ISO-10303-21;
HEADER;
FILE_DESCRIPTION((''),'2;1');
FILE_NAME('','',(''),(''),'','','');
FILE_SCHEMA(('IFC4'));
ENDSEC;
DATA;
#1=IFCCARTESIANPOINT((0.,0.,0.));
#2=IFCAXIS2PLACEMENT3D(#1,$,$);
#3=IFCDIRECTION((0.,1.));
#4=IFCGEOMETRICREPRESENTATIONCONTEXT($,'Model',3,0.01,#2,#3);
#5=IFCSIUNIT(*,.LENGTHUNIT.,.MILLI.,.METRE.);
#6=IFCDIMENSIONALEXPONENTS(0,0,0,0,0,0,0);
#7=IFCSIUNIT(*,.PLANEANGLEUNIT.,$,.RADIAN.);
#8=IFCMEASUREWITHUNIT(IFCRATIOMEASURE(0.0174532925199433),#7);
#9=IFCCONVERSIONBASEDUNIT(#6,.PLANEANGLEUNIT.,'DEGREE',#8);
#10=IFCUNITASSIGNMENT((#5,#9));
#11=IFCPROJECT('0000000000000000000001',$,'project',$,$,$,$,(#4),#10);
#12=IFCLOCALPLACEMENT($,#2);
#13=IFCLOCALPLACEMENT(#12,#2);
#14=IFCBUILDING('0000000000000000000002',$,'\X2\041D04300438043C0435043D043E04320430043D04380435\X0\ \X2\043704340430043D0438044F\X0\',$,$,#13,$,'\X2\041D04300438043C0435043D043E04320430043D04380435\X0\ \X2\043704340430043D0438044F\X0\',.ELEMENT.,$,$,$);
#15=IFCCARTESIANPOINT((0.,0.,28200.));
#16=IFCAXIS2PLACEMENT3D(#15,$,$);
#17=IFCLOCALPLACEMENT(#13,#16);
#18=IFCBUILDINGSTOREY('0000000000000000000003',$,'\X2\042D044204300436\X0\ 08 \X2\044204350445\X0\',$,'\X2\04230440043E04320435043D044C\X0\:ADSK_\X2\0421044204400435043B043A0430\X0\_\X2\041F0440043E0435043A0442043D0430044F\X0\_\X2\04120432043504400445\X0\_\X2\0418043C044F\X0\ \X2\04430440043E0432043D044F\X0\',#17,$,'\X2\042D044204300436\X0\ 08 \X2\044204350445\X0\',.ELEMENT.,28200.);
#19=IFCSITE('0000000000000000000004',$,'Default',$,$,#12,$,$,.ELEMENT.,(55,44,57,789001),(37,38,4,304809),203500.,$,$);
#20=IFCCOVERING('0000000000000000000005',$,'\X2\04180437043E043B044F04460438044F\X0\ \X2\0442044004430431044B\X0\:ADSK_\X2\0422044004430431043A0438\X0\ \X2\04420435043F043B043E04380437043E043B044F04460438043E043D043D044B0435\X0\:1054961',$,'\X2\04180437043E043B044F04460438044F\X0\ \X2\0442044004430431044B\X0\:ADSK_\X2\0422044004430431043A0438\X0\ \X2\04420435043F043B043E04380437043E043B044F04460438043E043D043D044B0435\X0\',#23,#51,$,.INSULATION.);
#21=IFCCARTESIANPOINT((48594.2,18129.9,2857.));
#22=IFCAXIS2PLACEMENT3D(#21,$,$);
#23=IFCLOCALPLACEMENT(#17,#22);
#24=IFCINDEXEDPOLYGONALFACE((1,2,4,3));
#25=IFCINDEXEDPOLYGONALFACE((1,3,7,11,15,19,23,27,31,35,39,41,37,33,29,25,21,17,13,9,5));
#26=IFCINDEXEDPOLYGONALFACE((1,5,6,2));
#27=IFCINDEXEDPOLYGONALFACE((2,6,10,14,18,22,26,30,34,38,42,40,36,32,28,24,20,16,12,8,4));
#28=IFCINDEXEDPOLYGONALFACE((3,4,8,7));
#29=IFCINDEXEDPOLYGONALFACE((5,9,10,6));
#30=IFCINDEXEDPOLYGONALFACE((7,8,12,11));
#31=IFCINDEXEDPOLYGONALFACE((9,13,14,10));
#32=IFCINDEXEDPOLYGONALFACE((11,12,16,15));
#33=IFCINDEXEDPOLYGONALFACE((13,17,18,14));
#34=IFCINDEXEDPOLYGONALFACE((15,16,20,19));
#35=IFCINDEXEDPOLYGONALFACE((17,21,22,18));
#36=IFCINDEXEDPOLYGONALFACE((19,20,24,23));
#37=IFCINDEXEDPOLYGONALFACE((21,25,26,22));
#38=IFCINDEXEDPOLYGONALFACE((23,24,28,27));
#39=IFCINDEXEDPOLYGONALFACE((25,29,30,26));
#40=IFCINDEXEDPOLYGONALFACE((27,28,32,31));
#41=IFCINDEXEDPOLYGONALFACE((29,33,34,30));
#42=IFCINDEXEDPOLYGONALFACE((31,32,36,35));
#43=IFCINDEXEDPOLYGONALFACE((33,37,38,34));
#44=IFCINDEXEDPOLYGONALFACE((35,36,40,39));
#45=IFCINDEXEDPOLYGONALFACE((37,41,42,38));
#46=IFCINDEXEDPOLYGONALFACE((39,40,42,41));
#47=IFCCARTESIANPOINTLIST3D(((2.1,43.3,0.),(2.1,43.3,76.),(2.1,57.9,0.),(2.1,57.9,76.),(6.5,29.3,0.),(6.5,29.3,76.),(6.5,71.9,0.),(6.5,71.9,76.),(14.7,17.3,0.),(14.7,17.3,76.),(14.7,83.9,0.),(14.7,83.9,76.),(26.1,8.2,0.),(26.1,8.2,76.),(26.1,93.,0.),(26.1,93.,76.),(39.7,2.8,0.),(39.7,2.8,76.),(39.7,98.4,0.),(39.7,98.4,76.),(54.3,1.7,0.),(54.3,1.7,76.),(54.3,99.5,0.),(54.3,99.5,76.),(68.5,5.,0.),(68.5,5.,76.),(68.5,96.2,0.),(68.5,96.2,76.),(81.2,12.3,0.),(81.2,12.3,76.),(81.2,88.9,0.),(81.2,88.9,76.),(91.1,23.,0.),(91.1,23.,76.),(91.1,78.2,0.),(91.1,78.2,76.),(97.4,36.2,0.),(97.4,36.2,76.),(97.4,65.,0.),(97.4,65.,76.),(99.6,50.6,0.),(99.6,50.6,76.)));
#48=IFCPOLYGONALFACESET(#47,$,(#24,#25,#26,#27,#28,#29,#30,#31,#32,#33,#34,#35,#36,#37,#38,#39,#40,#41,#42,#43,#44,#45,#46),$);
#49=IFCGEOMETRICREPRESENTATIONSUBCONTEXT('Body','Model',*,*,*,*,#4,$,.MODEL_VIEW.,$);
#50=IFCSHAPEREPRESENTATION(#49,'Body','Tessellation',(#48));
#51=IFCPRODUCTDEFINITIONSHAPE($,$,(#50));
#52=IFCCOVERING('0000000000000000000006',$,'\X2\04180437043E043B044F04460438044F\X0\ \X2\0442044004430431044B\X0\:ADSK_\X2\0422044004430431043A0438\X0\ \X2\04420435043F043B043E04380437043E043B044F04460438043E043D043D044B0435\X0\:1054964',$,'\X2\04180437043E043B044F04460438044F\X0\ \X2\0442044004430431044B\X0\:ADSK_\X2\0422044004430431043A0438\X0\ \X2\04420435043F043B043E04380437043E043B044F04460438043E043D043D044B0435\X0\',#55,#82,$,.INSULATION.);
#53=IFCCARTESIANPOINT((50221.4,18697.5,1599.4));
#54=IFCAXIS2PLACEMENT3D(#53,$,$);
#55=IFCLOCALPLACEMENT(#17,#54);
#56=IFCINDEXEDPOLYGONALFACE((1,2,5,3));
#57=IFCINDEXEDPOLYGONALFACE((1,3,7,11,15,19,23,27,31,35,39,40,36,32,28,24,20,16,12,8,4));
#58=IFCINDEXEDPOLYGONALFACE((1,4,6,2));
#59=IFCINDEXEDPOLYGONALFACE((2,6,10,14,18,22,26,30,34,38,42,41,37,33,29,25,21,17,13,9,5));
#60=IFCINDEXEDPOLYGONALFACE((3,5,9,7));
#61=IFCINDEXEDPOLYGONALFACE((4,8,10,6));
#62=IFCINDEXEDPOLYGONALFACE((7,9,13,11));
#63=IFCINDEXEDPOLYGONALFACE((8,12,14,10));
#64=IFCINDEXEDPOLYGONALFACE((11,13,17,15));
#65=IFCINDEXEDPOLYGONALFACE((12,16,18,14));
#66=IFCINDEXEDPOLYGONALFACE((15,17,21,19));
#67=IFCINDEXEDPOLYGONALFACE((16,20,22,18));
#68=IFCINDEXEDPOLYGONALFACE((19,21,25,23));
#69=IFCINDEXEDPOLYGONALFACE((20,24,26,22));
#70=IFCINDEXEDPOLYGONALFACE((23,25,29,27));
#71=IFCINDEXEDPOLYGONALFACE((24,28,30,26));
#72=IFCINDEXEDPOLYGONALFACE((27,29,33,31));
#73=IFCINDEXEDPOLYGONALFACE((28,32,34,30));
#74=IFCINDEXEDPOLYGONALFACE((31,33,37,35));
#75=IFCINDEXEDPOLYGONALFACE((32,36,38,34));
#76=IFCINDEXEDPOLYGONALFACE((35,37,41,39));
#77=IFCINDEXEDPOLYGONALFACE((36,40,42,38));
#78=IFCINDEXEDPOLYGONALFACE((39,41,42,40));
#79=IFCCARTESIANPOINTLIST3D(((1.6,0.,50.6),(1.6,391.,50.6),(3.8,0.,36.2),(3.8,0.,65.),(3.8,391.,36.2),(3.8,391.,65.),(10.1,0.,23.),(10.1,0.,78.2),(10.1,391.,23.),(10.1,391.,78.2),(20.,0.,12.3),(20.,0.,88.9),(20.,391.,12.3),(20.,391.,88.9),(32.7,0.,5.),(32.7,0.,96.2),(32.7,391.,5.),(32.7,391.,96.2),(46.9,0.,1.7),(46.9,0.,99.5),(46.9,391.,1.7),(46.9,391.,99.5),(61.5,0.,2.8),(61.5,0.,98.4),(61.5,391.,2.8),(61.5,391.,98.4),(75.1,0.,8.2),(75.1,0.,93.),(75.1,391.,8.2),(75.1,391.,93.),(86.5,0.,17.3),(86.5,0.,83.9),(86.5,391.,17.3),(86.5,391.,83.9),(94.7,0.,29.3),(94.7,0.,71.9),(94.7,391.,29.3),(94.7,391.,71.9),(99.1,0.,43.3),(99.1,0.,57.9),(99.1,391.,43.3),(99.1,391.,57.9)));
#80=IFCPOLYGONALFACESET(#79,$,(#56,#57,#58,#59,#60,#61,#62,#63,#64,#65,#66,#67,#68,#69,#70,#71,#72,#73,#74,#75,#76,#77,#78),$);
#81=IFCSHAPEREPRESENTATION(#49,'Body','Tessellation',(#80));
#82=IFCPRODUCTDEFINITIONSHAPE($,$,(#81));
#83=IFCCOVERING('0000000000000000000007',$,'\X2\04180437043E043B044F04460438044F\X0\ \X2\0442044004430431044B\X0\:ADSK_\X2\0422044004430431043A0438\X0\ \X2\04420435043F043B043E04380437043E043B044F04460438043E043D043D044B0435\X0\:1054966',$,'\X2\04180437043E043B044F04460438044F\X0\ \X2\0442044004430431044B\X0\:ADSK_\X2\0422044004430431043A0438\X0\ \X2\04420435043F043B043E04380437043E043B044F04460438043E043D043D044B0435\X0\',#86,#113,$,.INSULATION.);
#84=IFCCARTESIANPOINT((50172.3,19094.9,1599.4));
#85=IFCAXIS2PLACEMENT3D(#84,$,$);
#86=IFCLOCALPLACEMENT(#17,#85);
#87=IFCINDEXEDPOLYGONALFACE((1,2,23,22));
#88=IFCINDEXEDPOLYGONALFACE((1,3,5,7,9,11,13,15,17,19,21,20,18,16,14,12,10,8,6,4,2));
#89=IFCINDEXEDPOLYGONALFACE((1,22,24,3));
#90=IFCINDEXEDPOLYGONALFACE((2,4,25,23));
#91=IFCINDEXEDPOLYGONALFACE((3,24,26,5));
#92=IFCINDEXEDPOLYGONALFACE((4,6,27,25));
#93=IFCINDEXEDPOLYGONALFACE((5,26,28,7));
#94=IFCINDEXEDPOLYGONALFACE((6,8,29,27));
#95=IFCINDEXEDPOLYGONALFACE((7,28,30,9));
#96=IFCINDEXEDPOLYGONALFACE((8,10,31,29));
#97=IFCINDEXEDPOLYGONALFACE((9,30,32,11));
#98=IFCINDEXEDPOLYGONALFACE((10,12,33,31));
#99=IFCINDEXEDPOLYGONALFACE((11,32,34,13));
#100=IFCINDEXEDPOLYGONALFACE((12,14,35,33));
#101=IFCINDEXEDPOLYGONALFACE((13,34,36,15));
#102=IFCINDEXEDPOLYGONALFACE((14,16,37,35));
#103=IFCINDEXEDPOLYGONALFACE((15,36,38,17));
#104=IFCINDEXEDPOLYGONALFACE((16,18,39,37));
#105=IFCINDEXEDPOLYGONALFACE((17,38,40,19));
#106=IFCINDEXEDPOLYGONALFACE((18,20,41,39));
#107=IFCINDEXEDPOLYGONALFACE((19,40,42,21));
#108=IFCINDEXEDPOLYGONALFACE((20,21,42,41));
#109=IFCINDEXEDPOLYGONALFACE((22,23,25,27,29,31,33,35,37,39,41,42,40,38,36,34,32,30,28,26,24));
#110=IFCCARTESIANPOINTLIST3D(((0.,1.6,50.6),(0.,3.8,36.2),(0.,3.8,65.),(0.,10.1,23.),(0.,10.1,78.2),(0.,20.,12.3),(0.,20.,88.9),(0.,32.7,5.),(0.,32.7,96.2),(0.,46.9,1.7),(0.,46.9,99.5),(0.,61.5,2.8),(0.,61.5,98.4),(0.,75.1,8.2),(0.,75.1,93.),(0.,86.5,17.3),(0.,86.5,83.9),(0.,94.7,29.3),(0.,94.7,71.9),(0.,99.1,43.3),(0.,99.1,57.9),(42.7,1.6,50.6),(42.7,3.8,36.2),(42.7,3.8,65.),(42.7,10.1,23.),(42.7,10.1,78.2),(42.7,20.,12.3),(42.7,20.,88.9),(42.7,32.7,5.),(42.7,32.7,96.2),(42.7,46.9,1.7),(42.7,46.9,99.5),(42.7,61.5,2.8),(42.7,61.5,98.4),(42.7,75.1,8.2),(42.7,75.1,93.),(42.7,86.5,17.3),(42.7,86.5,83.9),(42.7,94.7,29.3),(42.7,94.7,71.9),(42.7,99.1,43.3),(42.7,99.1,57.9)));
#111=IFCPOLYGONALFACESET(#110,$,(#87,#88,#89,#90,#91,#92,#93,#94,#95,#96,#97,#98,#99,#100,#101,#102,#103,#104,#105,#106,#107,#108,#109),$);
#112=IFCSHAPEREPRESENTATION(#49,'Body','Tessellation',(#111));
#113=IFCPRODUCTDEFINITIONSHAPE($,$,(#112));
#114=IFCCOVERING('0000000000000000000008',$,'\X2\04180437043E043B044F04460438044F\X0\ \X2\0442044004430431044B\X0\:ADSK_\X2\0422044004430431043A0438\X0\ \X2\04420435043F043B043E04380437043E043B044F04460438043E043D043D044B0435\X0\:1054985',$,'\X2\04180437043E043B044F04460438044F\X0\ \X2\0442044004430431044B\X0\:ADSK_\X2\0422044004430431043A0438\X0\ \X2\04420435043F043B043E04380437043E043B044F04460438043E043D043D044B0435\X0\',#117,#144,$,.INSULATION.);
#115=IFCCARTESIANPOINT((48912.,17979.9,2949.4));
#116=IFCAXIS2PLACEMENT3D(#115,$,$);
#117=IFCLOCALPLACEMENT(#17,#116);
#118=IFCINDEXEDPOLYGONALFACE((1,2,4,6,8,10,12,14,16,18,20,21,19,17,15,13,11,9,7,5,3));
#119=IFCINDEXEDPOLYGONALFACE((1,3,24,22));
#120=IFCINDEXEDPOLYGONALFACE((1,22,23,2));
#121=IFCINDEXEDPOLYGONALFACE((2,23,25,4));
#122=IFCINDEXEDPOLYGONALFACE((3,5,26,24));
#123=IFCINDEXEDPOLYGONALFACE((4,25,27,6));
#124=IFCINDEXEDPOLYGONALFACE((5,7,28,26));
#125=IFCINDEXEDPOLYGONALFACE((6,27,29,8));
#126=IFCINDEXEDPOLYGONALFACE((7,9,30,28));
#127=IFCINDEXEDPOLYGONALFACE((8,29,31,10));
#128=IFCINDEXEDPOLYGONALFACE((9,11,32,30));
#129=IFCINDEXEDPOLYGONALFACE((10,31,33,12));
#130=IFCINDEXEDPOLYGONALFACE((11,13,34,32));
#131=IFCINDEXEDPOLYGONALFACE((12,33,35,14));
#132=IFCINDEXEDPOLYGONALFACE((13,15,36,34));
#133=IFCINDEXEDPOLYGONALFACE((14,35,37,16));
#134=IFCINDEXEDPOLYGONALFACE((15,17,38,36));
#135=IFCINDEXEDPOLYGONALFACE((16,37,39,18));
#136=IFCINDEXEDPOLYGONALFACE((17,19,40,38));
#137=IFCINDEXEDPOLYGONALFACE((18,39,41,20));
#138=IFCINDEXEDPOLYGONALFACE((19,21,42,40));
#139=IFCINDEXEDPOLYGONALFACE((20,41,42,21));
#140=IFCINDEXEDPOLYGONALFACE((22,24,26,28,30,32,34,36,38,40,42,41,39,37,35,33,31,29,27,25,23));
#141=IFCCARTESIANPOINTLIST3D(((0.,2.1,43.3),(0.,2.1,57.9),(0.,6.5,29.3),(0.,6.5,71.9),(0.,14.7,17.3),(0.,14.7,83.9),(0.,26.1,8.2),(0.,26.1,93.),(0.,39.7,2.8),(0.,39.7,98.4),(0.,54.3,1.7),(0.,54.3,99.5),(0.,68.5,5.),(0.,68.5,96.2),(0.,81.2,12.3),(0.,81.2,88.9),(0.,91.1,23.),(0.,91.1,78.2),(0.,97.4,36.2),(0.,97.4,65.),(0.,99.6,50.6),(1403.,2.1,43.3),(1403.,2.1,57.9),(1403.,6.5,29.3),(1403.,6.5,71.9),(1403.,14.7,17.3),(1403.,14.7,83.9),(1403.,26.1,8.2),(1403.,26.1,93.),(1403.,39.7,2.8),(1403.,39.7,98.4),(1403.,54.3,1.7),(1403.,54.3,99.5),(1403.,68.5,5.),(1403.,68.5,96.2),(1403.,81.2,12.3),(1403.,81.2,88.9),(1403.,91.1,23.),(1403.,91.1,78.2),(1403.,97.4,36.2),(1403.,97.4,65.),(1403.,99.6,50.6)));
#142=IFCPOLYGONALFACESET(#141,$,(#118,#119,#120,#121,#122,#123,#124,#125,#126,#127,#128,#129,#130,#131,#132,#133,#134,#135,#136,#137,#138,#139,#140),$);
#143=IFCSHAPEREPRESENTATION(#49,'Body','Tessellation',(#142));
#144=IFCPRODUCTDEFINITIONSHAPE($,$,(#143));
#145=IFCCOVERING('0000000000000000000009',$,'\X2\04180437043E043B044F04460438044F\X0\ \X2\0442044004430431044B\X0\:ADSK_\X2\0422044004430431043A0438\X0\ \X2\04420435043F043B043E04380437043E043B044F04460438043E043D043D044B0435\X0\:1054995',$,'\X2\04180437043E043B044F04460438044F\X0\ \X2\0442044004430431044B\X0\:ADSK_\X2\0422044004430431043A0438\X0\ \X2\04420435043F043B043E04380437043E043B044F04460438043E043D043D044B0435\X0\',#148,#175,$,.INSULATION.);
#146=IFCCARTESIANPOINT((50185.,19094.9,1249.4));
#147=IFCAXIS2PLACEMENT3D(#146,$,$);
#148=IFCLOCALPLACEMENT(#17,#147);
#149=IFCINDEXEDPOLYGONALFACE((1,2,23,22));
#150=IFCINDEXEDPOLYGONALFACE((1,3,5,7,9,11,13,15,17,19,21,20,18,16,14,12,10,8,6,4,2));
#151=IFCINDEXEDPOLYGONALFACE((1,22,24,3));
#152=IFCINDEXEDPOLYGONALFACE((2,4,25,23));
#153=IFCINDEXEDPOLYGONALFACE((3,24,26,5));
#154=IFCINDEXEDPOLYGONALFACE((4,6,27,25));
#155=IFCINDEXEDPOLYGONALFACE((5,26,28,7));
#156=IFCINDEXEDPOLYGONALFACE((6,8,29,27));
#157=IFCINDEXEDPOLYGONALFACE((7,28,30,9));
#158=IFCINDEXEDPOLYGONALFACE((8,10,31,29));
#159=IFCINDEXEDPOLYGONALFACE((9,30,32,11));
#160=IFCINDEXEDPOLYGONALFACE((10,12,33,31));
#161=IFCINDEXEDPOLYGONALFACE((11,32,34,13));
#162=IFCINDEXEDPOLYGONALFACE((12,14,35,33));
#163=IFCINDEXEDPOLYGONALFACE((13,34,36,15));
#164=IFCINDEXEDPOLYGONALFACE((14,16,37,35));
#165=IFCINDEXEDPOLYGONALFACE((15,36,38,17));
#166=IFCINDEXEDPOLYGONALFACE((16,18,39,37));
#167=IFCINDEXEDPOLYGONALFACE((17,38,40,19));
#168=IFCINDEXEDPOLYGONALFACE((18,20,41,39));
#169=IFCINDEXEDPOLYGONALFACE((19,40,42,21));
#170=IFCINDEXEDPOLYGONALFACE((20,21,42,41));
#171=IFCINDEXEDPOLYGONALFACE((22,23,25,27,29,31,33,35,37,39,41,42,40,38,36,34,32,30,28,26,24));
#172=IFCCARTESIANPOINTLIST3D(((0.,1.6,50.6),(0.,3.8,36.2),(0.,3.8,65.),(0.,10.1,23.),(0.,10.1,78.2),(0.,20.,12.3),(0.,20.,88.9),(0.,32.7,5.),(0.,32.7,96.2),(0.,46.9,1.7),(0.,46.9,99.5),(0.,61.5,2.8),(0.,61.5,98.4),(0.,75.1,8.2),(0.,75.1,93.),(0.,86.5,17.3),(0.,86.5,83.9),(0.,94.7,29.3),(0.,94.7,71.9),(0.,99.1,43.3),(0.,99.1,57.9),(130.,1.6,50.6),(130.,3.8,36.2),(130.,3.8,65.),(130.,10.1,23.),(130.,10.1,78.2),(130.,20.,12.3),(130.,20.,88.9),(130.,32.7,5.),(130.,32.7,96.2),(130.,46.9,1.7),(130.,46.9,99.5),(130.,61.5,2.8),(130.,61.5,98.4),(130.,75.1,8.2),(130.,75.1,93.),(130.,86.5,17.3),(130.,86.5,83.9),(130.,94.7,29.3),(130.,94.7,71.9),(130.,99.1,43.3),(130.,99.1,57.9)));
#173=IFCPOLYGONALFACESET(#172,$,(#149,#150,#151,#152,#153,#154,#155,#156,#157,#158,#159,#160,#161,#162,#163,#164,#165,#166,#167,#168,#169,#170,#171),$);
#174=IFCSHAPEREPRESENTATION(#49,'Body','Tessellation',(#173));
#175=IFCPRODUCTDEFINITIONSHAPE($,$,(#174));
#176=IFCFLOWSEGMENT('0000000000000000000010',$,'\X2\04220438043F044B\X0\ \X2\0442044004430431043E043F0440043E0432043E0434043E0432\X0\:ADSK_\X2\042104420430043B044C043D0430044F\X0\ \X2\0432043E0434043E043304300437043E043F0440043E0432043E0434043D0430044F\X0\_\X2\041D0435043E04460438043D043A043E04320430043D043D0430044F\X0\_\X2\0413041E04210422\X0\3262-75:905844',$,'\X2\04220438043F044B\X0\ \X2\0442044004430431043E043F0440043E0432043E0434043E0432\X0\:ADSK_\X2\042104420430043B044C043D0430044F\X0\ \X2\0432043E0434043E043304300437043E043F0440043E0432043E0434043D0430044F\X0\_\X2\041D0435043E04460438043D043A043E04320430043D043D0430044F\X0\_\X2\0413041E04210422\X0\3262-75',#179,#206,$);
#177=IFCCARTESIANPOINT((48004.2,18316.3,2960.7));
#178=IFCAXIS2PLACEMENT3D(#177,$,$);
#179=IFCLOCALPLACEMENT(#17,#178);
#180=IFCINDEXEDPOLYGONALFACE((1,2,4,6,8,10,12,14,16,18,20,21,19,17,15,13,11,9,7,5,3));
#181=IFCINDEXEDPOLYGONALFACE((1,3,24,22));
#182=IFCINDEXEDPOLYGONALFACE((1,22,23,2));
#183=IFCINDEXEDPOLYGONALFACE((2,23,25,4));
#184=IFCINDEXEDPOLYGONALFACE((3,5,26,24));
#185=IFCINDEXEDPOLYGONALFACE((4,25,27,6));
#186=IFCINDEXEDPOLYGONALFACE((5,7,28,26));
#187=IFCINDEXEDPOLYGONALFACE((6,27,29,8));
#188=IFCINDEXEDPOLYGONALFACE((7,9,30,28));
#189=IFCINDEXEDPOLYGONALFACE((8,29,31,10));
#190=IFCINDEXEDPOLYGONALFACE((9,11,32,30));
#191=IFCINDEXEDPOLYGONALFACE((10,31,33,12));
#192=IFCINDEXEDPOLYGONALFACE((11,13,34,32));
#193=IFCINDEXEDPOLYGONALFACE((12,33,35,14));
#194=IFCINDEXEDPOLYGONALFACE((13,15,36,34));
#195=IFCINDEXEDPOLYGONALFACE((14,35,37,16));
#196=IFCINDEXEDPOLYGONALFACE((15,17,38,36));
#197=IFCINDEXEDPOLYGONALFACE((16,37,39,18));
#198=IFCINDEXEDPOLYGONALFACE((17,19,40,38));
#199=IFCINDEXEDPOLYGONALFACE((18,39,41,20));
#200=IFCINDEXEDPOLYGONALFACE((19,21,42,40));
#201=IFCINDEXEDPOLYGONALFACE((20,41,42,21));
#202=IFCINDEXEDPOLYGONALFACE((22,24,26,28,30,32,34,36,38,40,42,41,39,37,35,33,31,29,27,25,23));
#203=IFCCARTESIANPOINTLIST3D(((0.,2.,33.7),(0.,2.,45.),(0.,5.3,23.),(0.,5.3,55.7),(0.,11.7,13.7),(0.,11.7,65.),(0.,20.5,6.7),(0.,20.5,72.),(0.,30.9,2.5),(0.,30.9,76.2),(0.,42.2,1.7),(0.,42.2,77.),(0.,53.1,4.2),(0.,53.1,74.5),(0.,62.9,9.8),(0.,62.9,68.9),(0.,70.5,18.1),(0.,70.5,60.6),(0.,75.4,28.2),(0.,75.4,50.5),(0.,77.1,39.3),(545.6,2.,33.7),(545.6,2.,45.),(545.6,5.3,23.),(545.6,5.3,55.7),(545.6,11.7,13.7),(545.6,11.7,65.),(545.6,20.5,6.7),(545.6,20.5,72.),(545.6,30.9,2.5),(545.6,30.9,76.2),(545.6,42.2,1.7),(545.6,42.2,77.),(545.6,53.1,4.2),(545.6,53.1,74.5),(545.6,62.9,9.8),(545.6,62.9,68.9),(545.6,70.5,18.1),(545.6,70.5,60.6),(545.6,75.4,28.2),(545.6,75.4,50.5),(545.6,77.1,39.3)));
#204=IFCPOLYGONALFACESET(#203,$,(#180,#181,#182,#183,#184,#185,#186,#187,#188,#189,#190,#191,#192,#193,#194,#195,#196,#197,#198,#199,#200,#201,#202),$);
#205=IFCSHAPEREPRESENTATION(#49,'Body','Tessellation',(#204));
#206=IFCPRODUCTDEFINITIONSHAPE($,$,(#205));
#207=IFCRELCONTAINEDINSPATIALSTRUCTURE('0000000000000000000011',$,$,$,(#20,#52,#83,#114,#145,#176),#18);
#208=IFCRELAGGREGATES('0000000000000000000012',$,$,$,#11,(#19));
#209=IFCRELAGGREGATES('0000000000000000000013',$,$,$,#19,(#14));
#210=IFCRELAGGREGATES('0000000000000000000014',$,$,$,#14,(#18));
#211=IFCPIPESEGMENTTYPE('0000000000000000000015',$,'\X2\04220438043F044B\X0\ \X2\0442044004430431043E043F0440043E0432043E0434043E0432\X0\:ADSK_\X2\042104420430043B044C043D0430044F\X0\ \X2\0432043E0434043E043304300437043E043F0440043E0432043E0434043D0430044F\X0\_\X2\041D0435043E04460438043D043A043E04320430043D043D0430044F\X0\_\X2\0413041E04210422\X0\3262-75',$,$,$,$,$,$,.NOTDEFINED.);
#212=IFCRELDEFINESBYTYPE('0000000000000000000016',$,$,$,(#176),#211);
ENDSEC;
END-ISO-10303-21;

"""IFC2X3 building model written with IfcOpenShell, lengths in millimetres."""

from ifc_helpers import new_model, entity, si_unit, converted_unit, direction, frame, origin, origin_2d_with_axis, place, context, subcontext, project, spatial, circle, extrude, type_object, element, save


model = new_model("IFC2X3")

# Units and contexts
model_context = context("Model", 3, precision=0.01, world=origin(), true_north=direction((0.0, 1.0)))
body_context = subcontext(model_context, "Body", "Model", "MODEL_VIEW")
ifc_project = project(units=[si_unit("LENGTHUNIT", "METRE", prefix="MILLI"), converted_unit("PLANEANGLEUNIT", "DEGREE", entity("IfcRatioMeasure", 0.0174532925199433), si_unit("PLANEANGLEUNIT", "RADIAN"), dimensions=[0, 0, 0, 0, 0, 0, 0])], contexts=[model_context])

# Site, building, storey
site_placement = place(None, origin())
site = spatial("IfcSite", under=ifc_project, at=site_placement, Name="Default", CompositionType="ELEMENT", RefLatitude=(55, 44, 57, 789001), RefLongitude=(37, 38, 4, 304809), RefElevation=203500.0)
building_placement = place(site_placement, origin())
building = spatial("IfcBuilding", under=site, at=building_placement, Name="Наименование здания", LongName="Наименование здания", CompositionType="ELEMENT")
storey_placement = place(building_placement, frame((0.0, 0.0, 28200.0)))
storey = spatial("IfcBuildingStorey", under=building, at=storey_placement, Name="Этаж 08 тех", ObjectType="Уровень:ADSK_Стрелка_Проектная_Вверх_Имя уровня", LongName="Этаж 08 тех", CompositionType="ELEMENT", Elevation=28200.0)

# Coverings
covering_1_placement = place(storey_placement, frame((48594.2, 18129.9, 2857.0)))
element("IfcCovering", 1, at=covering_1_placement, inside=storey, Name="Изоляция трубы:ADSK_Трубки теплоизоляционные:1054961", ObjectType="Изоляция трубы:ADSK_Трубки теплоизоляционные", PredefinedType="INSULATION", context=body_context, shape_type="SweptSolid", body=[
    extrude(circle(Radius=49.0, at=origin_2d_with_axis()), frame((50.6, 50.6, 0.0)), (0.0, 0.0, 1.0), 76.0),
])
covering_2_placement = place(storey_placement, frame((50221.4, 18697.5, 1599.4)))
element("IfcCovering", 2, at=covering_2_placement, inside=storey, Name="Изоляция трубы:ADSK_Трубки теплоизоляционные:1054964", ObjectType="Изоляция трубы:ADSK_Трубки теплоизоляционные", PredefinedType="INSULATION", context=body_context, shape_type="SweptSolid", body=[
    extrude(circle(Radius=49.0, at=origin_2d_with_axis()), frame((50.6, 0.0, 50.6), z_axis=(0.0, 1.0, 0.0), x_axis=(-1.0, 0.0, 0.0)), (0.0, 0.0, 1.0), 391.0),
])
covering_3_placement = place(storey_placement, frame((50172.3, 19094.9, 1599.4)))
element("IfcCovering", 3, at=covering_3_placement, inside=storey, Name="Изоляция трубы:ADSK_Трубки теплоизоляционные:1054966", ObjectType="Изоляция трубы:ADSK_Трубки теплоизоляционные", PredefinedType="INSULATION", context=body_context, shape_type="SweptSolid", body=[
    extrude(circle(Radius=49.0, at=origin_2d_with_axis()), frame((0.0, 50.6, 50.6), z_axis=(1.0, 0.0, 0.0), x_axis=(0.0, -1.0, 0.0)), (0.0, 0.0, 1.0), 42.7),
])
covering_4_placement = place(storey_placement, frame((48912.0, 17979.9, 2949.4)))
element("IfcCovering", 4, at=covering_4_placement, inside=storey, Name="Изоляция трубы:ADSK_Трубки теплоизоляционные:1054985", ObjectType="Изоляция трубы:ADSK_Трубки теплоизоляционные", PredefinedType="INSULATION", context=body_context, shape_type="SweptSolid", body=[
    extrude(circle(Radius=49.0, at=origin_2d_with_axis()), frame((0.0, 50.6, 50.6), z_axis=(1.0, 0.0, 0.0), x_axis=(0.0, 1.0, 0.0)), (0.0, 0.0, 1.0), 1403.0),
])
covering_5_placement = place(storey_placement, frame((50185.0, 19094.9, 1249.4)))
element("IfcCovering", 5, at=covering_5_placement, inside=storey, Name="Изоляция трубы:ADSK_Трубки теплоизоляционные:1054995", ObjectType="Изоляция трубы:ADSK_Трубки теплоизоляционные", PredefinedType="INSULATION", context=body_context, shape_type="SweptSolid", body=[
    extrude(circle(Radius=49.0, at=origin_2d_with_axis()), frame((0.0, 50.6, 50.6), z_axis=(1.0, 0.0, 0.0), x_axis=(0.0, -1.0, 0.0)), (0.0, 0.0, 1.0), 130.0),
])

# Flow segment
pipe_segment_type = type_object("IfcPipeSegmentType", Name="Типы трубопроводов:ADSK_Стальная водогазопроводная_Неоцинкованная_ГОСТ3262-75", PredefinedType="NOTDEFINED")
flow_segment_1_placement = place(storey_placement, frame((48004.2, 18316.3, 2960.7)))
element("IfcFlowSegment", 6, at=flow_segment_1_placement, inside=storey, type_object=pipe_segment_type, Name="Типы трубопроводов:ADSK_Стальная водогазопроводная_Неоцинкованная_ГОСТ3262-75:905844", ObjectType="Типы трубопроводов:ADSK_Стальная водогазопроводная_Неоцинкованная_ГОСТ3262-75", context=body_context, shape_type="SweptSolid", body=[
    extrude(circle(Radius=37.8, at=origin_2d_with_axis()), frame((0.0, 39.4, 39.4), z_axis=(1.0, 0.0, 0.0), x_axis=(0.0, 1.0, 0.0)), (0.0, 0.0, 1.0), 545.6),
])

save(model, "model.ifc")
